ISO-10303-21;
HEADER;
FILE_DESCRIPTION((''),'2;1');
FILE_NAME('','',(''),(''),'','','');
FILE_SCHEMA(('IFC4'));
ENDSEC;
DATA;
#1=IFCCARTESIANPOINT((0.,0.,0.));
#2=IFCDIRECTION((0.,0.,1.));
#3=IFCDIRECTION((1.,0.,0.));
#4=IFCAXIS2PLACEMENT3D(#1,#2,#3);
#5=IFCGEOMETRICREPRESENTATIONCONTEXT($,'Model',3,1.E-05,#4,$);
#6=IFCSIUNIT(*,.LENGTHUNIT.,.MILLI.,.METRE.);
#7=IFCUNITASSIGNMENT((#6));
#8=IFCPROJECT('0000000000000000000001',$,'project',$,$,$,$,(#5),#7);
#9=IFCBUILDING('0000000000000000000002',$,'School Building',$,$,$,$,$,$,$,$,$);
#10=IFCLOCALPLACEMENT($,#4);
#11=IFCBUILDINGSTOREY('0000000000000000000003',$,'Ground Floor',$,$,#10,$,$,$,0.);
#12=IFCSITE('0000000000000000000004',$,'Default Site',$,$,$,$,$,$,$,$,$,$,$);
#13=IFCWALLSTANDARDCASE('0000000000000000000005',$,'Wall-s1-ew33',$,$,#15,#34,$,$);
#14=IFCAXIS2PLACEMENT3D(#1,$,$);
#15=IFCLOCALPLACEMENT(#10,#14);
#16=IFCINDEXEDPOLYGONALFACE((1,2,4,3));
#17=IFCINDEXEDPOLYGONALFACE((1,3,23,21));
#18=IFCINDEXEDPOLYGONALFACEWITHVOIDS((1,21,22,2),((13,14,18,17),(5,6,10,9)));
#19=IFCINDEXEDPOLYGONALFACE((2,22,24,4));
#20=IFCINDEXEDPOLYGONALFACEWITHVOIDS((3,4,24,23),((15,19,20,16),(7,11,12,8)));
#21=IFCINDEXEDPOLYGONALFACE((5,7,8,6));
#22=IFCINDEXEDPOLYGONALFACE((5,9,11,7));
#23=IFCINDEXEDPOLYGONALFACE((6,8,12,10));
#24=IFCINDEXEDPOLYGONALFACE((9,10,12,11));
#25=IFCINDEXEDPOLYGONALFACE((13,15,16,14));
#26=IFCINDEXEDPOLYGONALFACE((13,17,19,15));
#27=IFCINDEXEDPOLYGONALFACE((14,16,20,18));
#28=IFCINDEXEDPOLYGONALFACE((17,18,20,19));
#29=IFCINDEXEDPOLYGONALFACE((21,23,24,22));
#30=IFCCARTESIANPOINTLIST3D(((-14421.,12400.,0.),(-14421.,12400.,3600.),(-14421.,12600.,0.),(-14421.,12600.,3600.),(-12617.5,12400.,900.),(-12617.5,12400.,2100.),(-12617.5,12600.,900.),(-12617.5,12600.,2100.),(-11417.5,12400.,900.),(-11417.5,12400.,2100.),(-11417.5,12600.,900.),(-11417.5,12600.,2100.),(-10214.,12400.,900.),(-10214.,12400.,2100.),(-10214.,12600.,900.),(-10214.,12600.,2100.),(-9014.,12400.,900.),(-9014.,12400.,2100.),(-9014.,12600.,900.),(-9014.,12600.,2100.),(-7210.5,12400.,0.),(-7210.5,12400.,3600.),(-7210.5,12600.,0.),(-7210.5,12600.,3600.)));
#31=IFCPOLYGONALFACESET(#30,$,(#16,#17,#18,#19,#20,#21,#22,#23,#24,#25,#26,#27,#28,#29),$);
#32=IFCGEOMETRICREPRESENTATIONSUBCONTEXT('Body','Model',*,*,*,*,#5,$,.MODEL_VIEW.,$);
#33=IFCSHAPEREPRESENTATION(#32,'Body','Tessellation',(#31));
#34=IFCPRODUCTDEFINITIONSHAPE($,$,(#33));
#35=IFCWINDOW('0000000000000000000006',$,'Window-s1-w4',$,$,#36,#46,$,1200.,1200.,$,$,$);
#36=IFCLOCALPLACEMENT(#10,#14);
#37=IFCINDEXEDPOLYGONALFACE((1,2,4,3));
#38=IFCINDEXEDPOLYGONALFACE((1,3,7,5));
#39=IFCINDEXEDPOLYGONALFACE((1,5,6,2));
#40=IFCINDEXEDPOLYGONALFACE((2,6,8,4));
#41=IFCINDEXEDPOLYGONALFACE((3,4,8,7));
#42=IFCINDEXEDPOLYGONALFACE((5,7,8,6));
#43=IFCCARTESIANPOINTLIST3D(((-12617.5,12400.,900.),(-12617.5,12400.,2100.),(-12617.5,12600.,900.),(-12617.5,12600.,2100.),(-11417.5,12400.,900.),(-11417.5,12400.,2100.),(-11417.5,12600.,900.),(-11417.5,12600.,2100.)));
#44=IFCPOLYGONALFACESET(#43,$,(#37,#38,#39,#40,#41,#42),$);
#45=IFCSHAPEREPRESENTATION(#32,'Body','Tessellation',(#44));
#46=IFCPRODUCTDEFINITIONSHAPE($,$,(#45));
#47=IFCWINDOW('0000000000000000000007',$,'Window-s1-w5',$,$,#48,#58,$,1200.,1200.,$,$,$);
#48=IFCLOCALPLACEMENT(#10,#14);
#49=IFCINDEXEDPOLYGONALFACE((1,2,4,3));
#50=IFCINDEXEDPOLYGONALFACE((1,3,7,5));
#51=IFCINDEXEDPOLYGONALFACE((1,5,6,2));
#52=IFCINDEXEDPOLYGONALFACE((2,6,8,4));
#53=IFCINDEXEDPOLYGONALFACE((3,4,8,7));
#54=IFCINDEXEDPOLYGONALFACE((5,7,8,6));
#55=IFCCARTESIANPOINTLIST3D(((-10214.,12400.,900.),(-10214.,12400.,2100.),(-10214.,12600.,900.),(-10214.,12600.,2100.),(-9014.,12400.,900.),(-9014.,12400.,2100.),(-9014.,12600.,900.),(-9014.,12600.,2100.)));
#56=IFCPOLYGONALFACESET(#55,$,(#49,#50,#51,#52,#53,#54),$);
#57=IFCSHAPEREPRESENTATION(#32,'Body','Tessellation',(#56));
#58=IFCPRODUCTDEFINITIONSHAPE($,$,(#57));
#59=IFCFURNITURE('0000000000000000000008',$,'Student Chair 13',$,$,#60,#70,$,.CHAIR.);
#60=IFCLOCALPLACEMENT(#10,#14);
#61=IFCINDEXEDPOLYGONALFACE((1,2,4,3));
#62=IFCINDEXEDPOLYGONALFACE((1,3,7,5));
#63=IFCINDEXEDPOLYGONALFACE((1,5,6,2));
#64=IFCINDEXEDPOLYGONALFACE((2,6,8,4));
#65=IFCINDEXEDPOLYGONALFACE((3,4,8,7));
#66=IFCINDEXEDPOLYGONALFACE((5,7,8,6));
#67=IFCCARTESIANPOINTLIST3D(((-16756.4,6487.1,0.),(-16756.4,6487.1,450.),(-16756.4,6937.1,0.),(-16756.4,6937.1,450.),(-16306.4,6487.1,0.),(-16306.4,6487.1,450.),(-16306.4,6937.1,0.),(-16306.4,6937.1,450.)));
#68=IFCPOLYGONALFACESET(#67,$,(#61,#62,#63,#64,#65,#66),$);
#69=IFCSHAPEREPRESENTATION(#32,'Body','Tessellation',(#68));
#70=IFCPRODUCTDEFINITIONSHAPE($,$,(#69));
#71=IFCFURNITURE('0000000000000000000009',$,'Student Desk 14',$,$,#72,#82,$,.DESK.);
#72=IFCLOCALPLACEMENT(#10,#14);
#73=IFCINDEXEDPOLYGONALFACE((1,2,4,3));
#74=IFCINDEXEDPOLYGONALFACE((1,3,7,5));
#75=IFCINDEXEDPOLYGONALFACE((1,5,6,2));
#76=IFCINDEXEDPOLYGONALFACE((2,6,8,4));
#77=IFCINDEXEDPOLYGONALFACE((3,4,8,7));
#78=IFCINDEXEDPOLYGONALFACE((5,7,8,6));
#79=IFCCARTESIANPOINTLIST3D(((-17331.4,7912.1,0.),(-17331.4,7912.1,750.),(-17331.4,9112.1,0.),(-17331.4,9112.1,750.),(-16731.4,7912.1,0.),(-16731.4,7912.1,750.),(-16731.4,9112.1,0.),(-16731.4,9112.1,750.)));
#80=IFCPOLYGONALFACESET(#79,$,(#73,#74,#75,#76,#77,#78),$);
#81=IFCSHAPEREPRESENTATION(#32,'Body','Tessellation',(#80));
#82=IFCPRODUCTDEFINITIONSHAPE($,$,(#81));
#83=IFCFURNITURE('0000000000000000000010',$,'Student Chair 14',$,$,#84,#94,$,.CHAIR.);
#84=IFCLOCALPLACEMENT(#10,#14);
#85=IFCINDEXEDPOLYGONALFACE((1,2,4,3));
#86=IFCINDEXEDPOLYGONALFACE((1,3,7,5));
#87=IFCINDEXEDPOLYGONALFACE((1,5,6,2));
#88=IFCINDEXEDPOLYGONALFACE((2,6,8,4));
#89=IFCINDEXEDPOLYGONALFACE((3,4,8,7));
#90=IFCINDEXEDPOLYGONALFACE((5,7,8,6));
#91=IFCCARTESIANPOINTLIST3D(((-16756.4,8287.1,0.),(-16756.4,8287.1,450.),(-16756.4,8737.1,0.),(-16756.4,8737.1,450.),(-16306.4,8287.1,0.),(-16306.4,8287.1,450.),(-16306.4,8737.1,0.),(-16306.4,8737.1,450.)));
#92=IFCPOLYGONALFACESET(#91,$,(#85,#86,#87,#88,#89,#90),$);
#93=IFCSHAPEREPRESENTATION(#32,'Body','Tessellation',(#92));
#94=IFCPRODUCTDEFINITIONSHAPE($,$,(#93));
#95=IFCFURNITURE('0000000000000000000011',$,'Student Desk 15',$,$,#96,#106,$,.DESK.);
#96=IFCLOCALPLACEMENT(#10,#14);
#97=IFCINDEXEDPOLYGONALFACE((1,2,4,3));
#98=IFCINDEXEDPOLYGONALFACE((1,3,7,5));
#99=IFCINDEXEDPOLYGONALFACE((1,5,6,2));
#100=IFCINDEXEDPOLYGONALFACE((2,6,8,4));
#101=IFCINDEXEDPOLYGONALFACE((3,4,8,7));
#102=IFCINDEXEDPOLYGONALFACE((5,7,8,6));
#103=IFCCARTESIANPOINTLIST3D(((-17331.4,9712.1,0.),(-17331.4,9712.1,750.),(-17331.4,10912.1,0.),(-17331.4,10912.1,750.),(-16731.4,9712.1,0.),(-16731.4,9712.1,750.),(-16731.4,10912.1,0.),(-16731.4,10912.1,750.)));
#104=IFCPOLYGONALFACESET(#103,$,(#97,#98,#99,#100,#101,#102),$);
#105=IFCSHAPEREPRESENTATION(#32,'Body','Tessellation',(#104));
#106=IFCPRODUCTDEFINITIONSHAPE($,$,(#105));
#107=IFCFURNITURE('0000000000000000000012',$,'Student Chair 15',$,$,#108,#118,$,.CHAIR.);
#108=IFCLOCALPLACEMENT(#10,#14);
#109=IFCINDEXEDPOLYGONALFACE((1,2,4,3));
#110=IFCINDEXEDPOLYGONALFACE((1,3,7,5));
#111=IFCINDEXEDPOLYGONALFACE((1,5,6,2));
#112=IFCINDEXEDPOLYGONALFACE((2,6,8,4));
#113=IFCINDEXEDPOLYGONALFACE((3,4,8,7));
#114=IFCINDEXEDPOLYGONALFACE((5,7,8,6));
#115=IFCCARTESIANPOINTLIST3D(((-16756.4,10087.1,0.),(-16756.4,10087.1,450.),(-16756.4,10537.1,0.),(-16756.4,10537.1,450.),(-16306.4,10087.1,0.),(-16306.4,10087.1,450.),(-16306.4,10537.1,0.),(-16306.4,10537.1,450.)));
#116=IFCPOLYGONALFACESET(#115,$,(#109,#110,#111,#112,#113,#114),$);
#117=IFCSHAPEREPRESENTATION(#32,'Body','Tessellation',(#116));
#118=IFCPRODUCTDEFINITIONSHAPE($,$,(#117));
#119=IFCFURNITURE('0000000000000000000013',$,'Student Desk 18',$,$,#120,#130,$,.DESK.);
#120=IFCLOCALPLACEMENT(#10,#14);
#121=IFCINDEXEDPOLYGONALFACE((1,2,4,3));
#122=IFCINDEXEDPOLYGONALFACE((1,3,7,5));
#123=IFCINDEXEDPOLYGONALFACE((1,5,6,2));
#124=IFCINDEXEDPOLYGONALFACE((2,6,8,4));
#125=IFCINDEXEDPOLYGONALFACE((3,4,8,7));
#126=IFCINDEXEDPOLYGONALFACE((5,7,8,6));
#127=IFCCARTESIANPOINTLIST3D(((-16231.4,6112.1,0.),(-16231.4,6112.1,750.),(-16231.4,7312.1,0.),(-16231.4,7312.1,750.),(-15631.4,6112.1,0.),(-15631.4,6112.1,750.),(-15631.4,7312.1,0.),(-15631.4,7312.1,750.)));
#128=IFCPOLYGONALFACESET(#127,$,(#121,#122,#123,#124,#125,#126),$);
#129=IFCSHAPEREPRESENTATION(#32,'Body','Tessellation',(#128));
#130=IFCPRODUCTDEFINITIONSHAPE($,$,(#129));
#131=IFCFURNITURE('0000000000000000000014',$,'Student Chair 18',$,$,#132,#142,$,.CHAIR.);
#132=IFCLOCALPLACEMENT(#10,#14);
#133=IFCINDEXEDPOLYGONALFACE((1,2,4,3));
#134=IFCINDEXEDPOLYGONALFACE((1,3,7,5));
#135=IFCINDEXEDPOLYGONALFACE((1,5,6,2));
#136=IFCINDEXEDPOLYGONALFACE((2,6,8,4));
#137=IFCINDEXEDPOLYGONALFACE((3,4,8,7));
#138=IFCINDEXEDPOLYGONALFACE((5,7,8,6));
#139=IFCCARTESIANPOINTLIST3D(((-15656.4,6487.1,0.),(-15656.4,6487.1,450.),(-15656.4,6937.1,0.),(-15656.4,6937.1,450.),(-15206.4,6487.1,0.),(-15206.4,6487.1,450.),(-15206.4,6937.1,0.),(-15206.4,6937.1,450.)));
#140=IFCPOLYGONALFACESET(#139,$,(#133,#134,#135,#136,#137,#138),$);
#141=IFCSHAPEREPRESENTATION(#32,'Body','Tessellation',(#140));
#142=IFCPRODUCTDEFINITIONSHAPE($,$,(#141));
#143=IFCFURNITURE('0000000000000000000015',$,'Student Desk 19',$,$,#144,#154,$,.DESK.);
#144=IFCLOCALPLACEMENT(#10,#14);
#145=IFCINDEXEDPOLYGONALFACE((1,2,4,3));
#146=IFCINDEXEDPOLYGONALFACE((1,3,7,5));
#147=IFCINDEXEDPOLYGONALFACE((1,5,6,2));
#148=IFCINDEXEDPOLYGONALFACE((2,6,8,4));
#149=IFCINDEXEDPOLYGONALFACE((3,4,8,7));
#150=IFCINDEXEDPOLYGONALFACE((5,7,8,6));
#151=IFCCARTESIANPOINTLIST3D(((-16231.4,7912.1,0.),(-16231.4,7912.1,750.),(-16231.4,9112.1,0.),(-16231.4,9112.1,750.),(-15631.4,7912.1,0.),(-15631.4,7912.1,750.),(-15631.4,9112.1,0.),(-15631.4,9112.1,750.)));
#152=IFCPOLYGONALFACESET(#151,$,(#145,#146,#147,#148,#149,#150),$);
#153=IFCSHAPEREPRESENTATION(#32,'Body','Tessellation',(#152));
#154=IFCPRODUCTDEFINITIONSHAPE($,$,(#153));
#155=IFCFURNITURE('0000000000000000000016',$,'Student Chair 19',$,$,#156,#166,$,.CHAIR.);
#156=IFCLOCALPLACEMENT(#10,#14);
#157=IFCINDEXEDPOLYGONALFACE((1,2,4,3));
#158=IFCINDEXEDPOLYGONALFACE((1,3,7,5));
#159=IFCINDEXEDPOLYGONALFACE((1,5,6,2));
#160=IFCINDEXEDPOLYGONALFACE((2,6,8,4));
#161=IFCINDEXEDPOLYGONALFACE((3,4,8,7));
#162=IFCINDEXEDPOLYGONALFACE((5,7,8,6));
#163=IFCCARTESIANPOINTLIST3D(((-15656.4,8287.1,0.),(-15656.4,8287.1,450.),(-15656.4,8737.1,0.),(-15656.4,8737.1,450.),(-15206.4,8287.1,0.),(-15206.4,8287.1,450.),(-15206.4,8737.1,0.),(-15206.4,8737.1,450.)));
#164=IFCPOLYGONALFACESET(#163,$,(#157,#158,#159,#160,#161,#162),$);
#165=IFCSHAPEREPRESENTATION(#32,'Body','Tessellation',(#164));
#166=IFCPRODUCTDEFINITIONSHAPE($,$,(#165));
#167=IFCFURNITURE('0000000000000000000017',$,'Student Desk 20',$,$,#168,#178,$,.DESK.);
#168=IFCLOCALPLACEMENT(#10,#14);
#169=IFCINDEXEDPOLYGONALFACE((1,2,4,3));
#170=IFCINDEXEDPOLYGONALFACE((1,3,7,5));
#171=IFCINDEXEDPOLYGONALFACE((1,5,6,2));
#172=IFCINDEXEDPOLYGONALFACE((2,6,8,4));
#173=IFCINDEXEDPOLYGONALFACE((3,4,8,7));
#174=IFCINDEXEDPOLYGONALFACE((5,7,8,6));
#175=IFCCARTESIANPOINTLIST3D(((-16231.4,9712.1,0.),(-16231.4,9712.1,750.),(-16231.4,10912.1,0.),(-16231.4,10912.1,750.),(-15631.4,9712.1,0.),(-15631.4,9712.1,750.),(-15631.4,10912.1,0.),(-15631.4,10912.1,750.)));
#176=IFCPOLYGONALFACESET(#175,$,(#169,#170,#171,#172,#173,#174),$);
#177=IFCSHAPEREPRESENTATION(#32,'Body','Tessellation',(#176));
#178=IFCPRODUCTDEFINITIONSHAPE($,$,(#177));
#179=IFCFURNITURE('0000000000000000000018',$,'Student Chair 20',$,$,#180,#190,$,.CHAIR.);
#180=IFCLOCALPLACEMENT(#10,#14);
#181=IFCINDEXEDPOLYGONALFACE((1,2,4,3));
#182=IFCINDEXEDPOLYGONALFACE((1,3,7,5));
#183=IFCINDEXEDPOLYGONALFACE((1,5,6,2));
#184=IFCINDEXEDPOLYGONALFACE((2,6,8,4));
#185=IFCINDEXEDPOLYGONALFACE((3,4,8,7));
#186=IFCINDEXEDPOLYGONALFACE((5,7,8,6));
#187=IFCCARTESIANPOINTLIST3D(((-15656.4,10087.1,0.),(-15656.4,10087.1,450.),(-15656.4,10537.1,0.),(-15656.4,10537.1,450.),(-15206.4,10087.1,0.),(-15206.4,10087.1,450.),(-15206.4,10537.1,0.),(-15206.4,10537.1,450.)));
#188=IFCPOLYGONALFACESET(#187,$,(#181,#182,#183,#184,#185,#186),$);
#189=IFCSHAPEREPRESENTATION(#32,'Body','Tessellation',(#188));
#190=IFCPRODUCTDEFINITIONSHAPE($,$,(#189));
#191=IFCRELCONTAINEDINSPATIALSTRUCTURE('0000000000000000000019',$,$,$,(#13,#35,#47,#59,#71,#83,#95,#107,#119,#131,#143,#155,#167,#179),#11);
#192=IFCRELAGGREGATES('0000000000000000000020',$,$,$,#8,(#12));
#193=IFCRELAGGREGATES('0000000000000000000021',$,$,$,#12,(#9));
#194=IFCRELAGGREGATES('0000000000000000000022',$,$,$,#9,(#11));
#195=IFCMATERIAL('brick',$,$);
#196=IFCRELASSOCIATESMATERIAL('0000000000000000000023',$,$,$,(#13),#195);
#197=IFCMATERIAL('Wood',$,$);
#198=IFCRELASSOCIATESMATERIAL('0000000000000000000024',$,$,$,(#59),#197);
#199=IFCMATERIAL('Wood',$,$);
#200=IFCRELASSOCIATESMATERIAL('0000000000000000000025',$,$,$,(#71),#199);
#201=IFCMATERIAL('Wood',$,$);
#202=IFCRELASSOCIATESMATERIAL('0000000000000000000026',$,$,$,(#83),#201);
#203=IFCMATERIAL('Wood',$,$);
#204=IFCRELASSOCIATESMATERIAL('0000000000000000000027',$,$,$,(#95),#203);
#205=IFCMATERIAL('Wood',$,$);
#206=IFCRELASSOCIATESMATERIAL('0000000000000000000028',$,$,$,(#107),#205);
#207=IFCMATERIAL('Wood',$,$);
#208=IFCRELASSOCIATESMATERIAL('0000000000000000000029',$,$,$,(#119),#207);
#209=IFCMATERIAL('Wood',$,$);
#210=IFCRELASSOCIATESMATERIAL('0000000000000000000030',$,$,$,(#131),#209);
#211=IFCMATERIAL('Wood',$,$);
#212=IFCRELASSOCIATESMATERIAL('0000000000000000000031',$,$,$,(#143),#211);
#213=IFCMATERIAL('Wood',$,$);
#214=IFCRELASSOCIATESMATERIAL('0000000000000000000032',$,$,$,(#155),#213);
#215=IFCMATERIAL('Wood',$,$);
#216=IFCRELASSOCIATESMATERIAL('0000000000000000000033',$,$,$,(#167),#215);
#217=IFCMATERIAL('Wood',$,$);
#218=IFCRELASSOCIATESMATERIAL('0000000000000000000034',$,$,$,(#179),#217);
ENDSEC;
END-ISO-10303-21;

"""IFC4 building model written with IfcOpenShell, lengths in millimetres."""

from ifc_helpers import new_model, si_unit, frame, frame_2d, origin_with_axes, origin_2d, place, context, subcontext, project, spatial, rectangle, extrude, material, element, fill, save


model = new_model("IFC4")

# Units and contexts
model_context = context("Model", 3, precision=1e-05, world=origin_with_axes())
body_context = subcontext(model_context, "Body", "Model", "MODEL_VIEW")
ifc_project = project(units=[si_unit("LENGTHUNIT", "METRE", prefix="MILLI")], contexts=[model_context])

# Site, building, storey
site = spatial("IfcSite", under=ifc_project, Name="Default Site")
building = spatial("IfcBuilding", under=site, Name="School Building")
storey_placement = place(None, origin_with_axes())
storey = spatial("IfcBuildingStorey", under=building, at=storey_placement, Name="Ground Floor", Elevation=0.0)

# Wall, openings, windows
ifc_material_1 = material(Name="brick")
wall_placement = place(storey_placement, frame((-14421.0, 12500.0, 0.0), z_axis=(0.0, 0.0, 1.0), x_axis=(1.0, 0.0, 0.0)))
wall = element("IfcWallStandardCase", 1, at=wall_placement, inside=storey, material=ifc_material_1, Name="Wall-s1-ew33", context=body_context, shape_type="SweptSolid", body=[
    extrude(rectangle(XDim=7210.5, YDim=200.0, at=frame_2d((3605.2, 0.0))), origin_with_axes(), (0.0, 0.0, 1.0), 3600.0),
])
opening_1_placement = place(wall_placement, frame((1803.5, 0.0, 900.0), z_axis=(0.0, 0.0, 1.0), x_axis=(1.0, 0.0, 0.0)))
opening_1 = element("IfcOpeningElement", 2, at=opening_1_placement, cuts=wall, context=body_context, shape_type="SweptSolid", body=[
    extrude(rectangle(XDim=1200.0, YDim=400.0, at=frame_2d((600.0, 0.0))), origin_with_axes(), (0.0, 0.0, 1.0), 1200.0),
])
opening_2_placement = place(wall_placement, frame((4207.0, 0.0, 900.0), z_axis=(0.0, 0.0, 1.0), x_axis=(1.0, 0.0, 0.0)))
opening_2 = element("IfcOpeningElement", 3, at=opening_2_placement, cuts=wall, context=body_context, shape_type="SweptSolid", body=[
    extrude(rectangle(XDim=1200.0, YDim=400.0, at=frame_2d((600.0, 0.0))), origin_with_axes(), (0.0, 0.0, 1.0), 1200.0),
])
window_1_placement = place(storey_placement, frame((-12617.5, 12500.0, 900.0), z_axis=(0.0, 0.0, 1.0), x_axis=(1.0, 0.0, 0.0)))
window_1 = element("IfcWindow", 4, at=window_1_placement, inside=storey, Name="Window-s1-w4", OverallHeight=1200.0, OverallWidth=1200.0, context=body_context, shape_type="SweptSolid", body=[
    extrude(rectangle(XDim=1200.0, YDim=200.0, at=frame_2d((600.0, 0.0))), origin_with_axes(), (0.0, 0.0, 1.0), 1200.0),
])
fill(opening_1, window_1)
window_2_placement = place(storey_placement, frame((-10214.0, 12500.0, 900.0), z_axis=(0.0, 0.0, 1.0), x_axis=(1.0, 0.0, 0.0)))
window_2 = element("IfcWindow", 5, at=window_2_placement, inside=storey, Name="Window-s1-w5", OverallHeight=1200.0, OverallWidth=1200.0, context=body_context, shape_type="SweptSolid", body=[
    extrude(rectangle(XDim=1200.0, YDim=200.0, at=frame_2d((600.0, 0.0))), origin_with_axes(), (0.0, 0.0, 1.0), 1200.0),
])
fill(opening_2, window_2)

# Furniture
ifc_material_2 = material(Name="Wood")
furniture_1_placement = place(storey_placement, frame((-16531.4, 6712.1, 0.0), z_axis=(0.0, 0.0, 1.0), x_axis=(1.0, 0.0, 0.0)))
element("IfcFurniture", 6, at=furniture_1_placement, inside=storey, material=ifc_material_2, Name="Student Chair 13", PredefinedType="CHAIR", context=body_context, shape_type="SweptSolid", body=[
    extrude(rectangle(XDim=450.0, YDim=450.0, at=origin_2d()), origin_with_axes(), (0.0, 0.0, 1.0), 450.0),
])
ifc_material_3 = material(Name="Wood")
furniture_2_placement = place(storey_placement, frame((-17031.4, 8512.1, 0.0), z_axis=(0.0, 0.0, 1.0), x_axis=(0.0, 1.0, 0.0)))
element("IfcFurniture", 7, at=furniture_2_placement, inside=storey, material=ifc_material_3, Name="Student Desk 14", PredefinedType="DESK", context=body_context, shape_type="SweptSolid", body=[
    extrude(rectangle(XDim=1200.0, YDim=600.0, at=origin_2d()), origin_with_axes(), (0.0, 0.0, 1.0), 750.0),
])
ifc_material_4 = material(Name="Wood")
furniture_3_placement = place(storey_placement, frame((-16531.4, 8512.1, 0.0), z_axis=(0.0, 0.0, 1.0), x_axis=(1.0, 0.0, 0.0)))
element("IfcFurniture", 8, at=furniture_3_placement, inside=storey, material=ifc_material_4, Name="Student Chair 14", PredefinedType="CHAIR", context=body_context, shape_type="SweptSolid", body=[
    extrude(rectangle(XDim=450.0, YDim=450.0, at=origin_2d()), origin_with_axes(), (0.0, 0.0, 1.0), 450.0),
])
ifc_material_5 = material(Name="Wood")
furniture_4_placement = place(storey_placement, frame((-17031.4, 10312.1, 0.0), z_axis=(0.0, 0.0, 1.0), x_axis=(0.0, 1.0, 0.0)))
element("IfcFurniture", 9, at=furniture_4_placement, inside=storey, material=ifc_material_5, Name="Student Desk 15", PredefinedType="DESK", context=body_context, shape_type="SweptSolid", body=[
    extrude(rectangle(XDim=1200.0, YDim=600.0, at=origin_2d()), origin_with_axes(), (0.0, 0.0, 1.0), 750.0),
])
ifc_material_6 = material(Name="Wood")
furniture_5_placement = place(storey_placement, frame((-16531.4, 10312.1, 0.0), z_axis=(0.0, 0.0, 1.0), x_axis=(1.0, 0.0, 0.0)))
element("IfcFurniture", 10, at=furniture_5_placement, inside=storey, material=ifc_material_6, Name="Student Chair 15", PredefinedType="CHAIR", context=body_context, shape_type="SweptSolid", body=[
    extrude(rectangle(XDim=450.0, YDim=450.0, at=origin_2d()), origin_with_axes(), (0.0, 0.0, 1.0), 450.0),
])
ifc_material_7 = material(Name="Wood")
furniture_6_placement = place(storey_placement, frame((-15931.4, 6712.1, 0.0), z_axis=(0.0, 0.0, 1.0), x_axis=(0.0, 1.0, 0.0)))
element("IfcFurniture", 11, at=furniture_6_placement, inside=storey, material=ifc_material_7, Name="Student Desk 18", PredefinedType="DESK", context=body_context, shape_type="SweptSolid", body=[
    extrude(rectangle(XDim=1200.0, YDim=600.0, at=origin_2d()), origin_with_axes(), (0.0, 0.0, 1.0), 750.0),
])
ifc_material_8 = material(Name="Wood")
furniture_7_placement = place(storey_placement, frame((-15431.4, 6712.1, 0.0), z_axis=(0.0, 0.0, 1.0), x_axis=(1.0, 0.0, 0.0)))
element("IfcFurniture", 12, at=furniture_7_placement, inside=storey, material=ifc_material_8, Name="Student Chair 18", PredefinedType="CHAIR", context=body_context, shape_type="SweptSolid", body=[
    extrude(rectangle(XDim=450.0, YDim=450.0, at=origin_2d()), origin_with_axes(), (0.0, 0.0, 1.0), 450.0),
])
ifc_material_9 = material(Name="Wood")
furniture_8_placement = place(storey_placement, frame((-15931.4, 8512.1, 0.0), z_axis=(0.0, 0.0, 1.0), x_axis=(0.0, 1.0, 0.0)))
element("IfcFurniture", 13, at=furniture_8_placement, inside=storey, material=ifc_material_9, Name="Student Desk 19", PredefinedType="DESK", context=body_context, shape_type="SweptSolid", body=[
    extrude(rectangle(XDim=1200.0, YDim=600.0, at=origin_2d()), origin_with_axes(), (0.0, 0.0, 1.0), 750.0),
])
ifc_material_10 = material(Name="Wood")
furniture_9_placement = place(storey_placement, frame((-15431.4, 8512.1, 0.0), z_axis=(0.0, 0.0, 1.0), x_axis=(1.0, 0.0, 0.0)))
element("IfcFurniture", 14, at=furniture_9_placement, inside=storey, material=ifc_material_10, Name="Student Chair 19", PredefinedType="CHAIR", context=body_context, shape_type="SweptSolid", body=[
    extrude(rectangle(XDim=450.0, YDim=450.0, at=origin_2d()), origin_with_axes(), (0.0, 0.0, 1.0), 450.0),
])
ifc_material_11 = material(Name="Wood")
furniture_10_placement = place(storey_placement, frame((-15931.4, 10312.1, 0.0), z_axis=(0.0, 0.0, 1.0), x_axis=(0.0, 1.0, 0.0)))
element("IfcFurniture", 15, at=furniture_10_placement, inside=storey, material=ifc_material_11, Name="Student Desk 20", PredefinedType="DESK", context=body_context, shape_type="SweptSolid", body=[
    extrude(rectangle(XDim=1200.0, YDim=600.0, at=origin_2d()), origin_with_axes(), (0.0, 0.0, 1.0), 750.0),
])
ifc_material_12 = material(Name="Wood")
furniture_11_placement = place(storey_placement, frame((-15431.4, 10312.1, 0.0), z_axis=(0.0, 0.0, 1.0), x_axis=(1.0, 0.0, 0.0)))
element("IfcFurniture", 16, at=furniture_11_placement, inside=storey, material=ifc_material_12, Name="Student Chair 20", PredefinedType="CHAIR", context=body_context, shape_type="SweptSolid", body=[
    extrude(rectangle(XDim=450.0, YDim=450.0, at=origin_2d()), origin_with_axes(), (0.0, 0.0, 1.0), 450.0),
])

save(model, "model.ifc")
